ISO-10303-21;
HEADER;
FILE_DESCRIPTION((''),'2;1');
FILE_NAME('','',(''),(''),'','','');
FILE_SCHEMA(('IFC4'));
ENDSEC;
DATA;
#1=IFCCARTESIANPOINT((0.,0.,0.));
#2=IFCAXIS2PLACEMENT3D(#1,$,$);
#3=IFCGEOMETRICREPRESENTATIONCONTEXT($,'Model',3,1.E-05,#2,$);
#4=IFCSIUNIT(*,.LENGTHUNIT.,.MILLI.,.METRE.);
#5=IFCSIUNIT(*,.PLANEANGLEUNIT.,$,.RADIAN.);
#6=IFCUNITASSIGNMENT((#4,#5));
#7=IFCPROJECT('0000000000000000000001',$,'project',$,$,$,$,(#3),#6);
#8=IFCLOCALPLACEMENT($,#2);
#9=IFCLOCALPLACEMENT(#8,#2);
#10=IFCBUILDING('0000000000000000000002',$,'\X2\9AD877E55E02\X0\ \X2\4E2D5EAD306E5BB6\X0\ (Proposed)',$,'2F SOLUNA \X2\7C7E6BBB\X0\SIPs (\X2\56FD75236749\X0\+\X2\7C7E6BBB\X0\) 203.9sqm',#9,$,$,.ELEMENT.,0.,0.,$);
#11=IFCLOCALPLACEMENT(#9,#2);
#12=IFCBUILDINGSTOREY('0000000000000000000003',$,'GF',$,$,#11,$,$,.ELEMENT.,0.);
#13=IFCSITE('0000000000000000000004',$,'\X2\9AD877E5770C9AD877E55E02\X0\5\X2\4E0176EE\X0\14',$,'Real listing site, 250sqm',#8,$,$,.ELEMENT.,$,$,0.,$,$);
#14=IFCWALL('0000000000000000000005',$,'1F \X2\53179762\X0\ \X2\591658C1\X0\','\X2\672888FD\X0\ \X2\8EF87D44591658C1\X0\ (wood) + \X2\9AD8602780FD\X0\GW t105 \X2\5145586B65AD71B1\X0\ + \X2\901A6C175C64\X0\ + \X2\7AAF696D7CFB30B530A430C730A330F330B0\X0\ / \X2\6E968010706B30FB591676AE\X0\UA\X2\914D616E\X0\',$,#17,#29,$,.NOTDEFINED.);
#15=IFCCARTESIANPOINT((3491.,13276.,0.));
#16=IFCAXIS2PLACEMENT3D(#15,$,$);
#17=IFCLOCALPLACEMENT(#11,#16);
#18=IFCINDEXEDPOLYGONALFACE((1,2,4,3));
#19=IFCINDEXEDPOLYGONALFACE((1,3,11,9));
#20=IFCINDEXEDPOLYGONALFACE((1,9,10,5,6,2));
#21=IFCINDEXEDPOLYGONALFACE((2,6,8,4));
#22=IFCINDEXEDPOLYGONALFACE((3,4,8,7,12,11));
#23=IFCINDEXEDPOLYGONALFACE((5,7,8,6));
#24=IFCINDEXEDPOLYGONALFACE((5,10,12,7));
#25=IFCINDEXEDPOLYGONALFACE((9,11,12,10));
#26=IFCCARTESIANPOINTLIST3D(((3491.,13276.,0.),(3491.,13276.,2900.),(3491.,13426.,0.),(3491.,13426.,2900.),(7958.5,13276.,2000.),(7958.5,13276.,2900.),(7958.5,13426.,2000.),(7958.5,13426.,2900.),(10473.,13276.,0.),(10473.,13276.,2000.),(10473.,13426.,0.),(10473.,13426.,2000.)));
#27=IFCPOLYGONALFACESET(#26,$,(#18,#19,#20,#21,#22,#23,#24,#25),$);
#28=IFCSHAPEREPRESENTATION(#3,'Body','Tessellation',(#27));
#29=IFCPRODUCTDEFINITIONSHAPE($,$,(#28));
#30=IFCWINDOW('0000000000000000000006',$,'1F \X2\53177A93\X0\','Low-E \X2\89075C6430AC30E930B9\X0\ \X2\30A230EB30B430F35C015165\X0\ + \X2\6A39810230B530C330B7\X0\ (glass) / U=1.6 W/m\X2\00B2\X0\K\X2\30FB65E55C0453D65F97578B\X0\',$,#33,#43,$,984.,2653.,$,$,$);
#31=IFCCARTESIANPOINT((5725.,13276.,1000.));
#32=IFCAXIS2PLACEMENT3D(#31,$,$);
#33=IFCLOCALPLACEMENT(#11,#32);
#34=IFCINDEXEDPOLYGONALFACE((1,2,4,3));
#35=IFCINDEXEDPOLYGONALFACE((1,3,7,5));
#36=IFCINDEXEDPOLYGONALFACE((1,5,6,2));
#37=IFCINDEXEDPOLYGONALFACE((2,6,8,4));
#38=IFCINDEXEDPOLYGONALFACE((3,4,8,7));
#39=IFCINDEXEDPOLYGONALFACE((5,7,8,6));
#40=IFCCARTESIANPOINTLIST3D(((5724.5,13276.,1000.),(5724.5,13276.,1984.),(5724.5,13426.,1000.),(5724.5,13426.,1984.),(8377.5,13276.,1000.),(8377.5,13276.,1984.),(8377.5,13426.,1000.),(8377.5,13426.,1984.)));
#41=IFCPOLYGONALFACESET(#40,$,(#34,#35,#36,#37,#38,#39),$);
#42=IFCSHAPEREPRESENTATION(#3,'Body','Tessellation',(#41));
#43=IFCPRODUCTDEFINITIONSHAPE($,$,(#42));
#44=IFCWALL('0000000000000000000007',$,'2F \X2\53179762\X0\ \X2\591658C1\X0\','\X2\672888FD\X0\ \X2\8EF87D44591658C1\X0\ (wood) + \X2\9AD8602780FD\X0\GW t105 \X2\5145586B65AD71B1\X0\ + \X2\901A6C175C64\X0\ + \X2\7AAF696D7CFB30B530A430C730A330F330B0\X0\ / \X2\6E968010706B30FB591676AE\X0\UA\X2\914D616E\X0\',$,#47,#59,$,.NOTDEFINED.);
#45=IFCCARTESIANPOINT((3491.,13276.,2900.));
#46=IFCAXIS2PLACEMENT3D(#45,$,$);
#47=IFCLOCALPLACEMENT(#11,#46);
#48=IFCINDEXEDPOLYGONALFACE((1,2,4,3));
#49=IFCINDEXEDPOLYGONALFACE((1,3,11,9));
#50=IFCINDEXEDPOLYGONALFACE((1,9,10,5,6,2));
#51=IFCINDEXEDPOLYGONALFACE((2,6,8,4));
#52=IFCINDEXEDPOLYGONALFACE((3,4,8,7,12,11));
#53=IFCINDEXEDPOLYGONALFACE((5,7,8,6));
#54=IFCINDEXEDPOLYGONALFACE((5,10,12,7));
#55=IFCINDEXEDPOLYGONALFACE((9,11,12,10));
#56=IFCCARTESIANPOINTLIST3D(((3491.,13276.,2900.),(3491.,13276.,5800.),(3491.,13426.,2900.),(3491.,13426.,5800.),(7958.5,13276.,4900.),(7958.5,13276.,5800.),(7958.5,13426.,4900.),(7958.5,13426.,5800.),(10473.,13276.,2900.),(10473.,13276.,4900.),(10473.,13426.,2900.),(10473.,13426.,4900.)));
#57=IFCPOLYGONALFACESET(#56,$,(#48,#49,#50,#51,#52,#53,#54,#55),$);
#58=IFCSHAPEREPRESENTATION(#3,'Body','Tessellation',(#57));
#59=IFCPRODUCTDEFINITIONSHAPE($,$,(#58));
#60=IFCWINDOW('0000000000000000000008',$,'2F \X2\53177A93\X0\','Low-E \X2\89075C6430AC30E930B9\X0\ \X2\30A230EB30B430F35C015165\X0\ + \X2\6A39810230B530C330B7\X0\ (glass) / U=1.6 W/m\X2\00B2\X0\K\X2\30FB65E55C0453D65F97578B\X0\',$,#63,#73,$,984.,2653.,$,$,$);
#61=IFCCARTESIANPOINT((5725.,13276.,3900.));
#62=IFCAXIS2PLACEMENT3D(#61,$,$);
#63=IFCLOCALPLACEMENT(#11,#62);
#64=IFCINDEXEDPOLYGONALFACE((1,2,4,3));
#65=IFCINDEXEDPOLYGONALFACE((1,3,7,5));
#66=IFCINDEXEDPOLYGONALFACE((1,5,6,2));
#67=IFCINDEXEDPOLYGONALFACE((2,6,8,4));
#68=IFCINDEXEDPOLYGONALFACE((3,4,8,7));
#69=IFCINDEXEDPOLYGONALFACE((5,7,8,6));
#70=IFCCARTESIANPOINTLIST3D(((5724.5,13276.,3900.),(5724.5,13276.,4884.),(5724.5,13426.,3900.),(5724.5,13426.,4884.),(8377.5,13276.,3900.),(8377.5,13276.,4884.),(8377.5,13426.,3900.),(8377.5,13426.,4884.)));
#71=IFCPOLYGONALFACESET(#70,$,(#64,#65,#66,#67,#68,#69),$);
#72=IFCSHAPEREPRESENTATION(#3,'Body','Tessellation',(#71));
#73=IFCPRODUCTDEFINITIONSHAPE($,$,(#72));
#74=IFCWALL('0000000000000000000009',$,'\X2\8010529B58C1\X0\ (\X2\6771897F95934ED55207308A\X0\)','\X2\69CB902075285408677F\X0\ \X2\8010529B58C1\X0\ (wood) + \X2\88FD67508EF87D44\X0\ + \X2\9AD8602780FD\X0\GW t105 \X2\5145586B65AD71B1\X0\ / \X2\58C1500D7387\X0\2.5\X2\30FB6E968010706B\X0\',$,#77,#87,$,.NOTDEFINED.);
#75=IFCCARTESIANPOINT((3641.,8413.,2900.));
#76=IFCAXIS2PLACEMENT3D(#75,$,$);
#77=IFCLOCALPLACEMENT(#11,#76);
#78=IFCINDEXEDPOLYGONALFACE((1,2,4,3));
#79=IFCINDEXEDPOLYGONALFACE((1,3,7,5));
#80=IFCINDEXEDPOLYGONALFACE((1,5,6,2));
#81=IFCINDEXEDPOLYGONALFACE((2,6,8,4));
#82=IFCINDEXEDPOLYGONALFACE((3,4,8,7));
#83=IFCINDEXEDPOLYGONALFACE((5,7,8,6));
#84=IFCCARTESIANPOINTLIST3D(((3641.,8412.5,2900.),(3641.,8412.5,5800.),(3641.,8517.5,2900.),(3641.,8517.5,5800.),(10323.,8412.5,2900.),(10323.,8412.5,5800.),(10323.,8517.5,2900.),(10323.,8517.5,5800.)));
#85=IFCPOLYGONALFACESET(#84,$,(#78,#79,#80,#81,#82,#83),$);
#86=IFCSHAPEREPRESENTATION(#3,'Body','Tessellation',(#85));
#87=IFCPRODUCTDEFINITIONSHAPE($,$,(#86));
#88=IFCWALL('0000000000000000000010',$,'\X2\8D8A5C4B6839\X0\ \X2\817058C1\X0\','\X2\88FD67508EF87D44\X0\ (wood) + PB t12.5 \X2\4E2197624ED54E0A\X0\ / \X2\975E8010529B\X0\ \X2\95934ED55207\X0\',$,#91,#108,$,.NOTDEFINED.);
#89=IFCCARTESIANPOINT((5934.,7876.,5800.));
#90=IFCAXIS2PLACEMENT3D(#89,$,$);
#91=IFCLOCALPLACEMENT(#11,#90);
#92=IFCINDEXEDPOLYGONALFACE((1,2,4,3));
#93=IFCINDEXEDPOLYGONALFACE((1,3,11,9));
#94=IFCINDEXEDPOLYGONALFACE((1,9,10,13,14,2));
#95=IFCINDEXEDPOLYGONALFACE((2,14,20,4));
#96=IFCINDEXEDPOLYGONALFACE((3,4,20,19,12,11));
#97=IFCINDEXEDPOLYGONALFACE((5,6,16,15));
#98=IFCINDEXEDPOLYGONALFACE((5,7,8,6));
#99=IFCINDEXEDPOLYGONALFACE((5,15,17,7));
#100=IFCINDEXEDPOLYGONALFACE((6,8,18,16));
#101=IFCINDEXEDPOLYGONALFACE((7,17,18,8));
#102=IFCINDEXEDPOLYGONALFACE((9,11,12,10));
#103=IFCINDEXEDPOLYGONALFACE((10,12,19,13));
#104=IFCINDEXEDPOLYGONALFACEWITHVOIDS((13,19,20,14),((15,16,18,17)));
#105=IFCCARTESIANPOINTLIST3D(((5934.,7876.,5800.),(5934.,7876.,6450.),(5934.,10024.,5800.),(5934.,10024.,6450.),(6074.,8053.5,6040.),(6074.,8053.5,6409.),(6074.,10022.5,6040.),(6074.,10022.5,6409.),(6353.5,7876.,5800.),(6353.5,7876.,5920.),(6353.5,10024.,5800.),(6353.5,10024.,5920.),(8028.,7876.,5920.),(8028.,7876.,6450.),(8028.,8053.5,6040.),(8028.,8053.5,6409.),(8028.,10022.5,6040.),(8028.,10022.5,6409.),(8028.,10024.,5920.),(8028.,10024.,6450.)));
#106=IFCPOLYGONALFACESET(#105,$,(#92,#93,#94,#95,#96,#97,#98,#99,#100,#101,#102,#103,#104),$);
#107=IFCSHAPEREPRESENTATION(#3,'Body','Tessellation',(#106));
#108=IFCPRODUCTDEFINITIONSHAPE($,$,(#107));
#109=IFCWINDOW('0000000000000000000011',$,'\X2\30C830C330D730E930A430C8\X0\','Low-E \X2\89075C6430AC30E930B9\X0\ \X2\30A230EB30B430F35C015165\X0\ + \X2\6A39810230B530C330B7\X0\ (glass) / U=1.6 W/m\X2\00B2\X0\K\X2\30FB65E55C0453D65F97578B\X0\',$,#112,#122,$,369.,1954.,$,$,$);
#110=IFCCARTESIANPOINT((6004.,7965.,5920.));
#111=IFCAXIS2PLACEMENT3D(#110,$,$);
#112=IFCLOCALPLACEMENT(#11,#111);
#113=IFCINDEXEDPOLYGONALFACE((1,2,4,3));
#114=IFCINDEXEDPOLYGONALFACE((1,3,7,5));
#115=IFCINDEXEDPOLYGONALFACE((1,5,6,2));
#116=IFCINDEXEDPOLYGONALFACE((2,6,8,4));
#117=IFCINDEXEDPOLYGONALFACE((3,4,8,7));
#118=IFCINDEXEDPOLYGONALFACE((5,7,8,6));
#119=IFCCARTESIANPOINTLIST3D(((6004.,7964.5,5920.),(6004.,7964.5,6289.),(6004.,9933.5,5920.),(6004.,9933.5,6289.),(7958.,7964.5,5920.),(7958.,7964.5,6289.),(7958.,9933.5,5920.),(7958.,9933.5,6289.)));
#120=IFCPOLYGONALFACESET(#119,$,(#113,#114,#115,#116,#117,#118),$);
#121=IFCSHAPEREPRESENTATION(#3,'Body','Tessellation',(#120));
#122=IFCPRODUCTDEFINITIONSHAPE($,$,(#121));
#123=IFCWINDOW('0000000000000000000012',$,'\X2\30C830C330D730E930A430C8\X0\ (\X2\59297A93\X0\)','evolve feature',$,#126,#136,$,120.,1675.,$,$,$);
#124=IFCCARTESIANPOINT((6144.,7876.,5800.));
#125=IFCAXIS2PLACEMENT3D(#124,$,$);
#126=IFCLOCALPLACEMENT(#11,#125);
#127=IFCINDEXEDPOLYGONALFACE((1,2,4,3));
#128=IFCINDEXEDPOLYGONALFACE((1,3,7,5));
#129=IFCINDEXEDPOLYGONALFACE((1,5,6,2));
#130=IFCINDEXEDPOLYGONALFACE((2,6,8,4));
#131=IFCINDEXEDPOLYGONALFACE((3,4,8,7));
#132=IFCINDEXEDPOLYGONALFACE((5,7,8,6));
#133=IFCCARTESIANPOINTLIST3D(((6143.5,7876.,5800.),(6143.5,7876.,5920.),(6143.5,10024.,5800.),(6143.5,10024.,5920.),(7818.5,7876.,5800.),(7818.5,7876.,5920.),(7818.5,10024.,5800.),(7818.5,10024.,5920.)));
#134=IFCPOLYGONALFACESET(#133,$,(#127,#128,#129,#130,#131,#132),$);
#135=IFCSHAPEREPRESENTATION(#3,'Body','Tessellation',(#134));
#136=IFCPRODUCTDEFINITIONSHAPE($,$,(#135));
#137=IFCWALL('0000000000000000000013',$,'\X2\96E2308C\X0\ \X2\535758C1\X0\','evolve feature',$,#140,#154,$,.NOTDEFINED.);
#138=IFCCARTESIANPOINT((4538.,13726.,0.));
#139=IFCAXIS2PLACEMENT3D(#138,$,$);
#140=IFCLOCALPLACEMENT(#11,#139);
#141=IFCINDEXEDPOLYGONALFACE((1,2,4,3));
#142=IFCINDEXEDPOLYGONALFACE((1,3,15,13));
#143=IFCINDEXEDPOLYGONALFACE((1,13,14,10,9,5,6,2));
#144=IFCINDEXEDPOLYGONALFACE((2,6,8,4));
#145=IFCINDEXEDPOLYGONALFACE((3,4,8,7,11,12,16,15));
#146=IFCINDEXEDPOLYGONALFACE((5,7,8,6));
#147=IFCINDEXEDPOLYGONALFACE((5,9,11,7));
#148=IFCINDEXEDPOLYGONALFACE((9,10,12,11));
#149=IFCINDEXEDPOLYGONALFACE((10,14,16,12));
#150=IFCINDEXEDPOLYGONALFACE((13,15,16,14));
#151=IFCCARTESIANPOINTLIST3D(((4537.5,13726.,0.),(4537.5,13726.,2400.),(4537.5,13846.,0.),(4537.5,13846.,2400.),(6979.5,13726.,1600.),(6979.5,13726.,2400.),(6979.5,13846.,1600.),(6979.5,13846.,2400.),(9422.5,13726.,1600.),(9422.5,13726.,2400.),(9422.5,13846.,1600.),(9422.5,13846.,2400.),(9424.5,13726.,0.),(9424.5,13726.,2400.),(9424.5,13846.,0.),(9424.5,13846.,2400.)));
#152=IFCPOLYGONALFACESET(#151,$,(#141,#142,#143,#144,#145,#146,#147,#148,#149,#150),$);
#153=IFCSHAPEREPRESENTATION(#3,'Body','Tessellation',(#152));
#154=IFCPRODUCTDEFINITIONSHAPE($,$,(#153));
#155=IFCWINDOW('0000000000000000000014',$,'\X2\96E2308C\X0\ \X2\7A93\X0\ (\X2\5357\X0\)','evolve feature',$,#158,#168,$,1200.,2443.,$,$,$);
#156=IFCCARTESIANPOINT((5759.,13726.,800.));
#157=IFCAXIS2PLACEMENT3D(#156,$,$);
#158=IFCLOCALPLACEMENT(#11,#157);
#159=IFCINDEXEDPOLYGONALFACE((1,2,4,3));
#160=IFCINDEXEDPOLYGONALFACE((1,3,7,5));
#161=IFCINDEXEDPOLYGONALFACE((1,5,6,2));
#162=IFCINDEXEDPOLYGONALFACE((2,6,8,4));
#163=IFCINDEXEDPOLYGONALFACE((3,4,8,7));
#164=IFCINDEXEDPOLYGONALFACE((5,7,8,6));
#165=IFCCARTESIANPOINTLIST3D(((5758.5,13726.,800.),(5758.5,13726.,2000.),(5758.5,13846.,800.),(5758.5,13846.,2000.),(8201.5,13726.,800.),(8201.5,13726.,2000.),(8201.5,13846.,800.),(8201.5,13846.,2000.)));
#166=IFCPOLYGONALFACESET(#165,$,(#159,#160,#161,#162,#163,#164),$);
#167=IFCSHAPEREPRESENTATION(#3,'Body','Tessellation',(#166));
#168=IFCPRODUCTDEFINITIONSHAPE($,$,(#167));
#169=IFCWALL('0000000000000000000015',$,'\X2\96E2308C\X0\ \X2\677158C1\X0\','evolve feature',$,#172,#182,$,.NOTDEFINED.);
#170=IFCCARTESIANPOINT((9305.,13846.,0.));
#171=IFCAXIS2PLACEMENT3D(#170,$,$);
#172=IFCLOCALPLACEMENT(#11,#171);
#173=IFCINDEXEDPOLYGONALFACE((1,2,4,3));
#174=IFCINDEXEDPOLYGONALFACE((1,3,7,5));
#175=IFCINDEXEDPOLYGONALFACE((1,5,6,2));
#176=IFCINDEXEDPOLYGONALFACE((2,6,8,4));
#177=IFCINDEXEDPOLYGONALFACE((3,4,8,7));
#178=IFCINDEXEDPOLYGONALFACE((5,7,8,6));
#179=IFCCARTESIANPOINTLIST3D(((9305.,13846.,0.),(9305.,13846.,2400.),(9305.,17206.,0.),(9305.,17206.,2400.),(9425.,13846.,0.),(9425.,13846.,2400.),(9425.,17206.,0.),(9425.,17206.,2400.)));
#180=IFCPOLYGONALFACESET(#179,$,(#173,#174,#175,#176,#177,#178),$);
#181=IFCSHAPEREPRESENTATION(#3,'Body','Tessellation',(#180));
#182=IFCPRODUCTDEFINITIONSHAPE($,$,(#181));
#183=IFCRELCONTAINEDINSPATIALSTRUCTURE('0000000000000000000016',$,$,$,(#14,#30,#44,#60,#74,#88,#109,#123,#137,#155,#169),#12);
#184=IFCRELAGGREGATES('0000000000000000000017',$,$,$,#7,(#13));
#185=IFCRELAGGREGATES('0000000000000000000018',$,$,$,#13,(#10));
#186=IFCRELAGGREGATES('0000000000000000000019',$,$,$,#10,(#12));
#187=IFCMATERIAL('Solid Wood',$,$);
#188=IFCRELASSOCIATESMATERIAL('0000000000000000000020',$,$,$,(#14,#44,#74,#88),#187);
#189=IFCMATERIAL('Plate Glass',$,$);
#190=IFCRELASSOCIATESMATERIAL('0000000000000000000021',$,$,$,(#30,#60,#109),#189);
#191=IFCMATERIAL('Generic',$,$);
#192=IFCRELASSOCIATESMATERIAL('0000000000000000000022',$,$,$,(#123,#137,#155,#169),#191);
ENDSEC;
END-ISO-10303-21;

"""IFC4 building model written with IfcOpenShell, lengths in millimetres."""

from ifc_helpers import new_model, si_unit, frame, frame_2d, origin, place, context, project, spatial, rectangle, extrude, material, element, fill, save


model = new_model("IFC4")

# Units and contexts
model_context = context("Model", 3, precision=1e-05, world=origin())
ifc_project = project(units=[si_unit("LENGTHUNIT", "METRE", prefix="MILLI"), si_unit("PLANEANGLEUNIT", "RADIAN")], contexts=[model_context])

# Site, building, storey
site_placement = place(None, origin())
site = spatial("IfcSite", under=ifc_project, at=site_placement, Name="高知県高知市5丁目14", ObjectType="Real listing site, 250sqm", CompositionType="ELEMENT", RefElevation=0.0)
building_placement = place(site_placement, origin())
building = spatial("IfcBuilding", under=site, at=building_placement, Name="高知市 中庭の家 (Proposed)", ObjectType="2F SOLUNA 籾殻SIPs (国産杉+籾殻) 203.9sqm", CompositionType="ELEMENT", ElevationOfRefHeight=0.0, ElevationOfTerrain=0.0)
storey_placement = place(building_placement, origin())
storey = spatial("IfcBuildingStorey", under=building, at=storey_placement, Name="GF", CompositionType="ELEMENT", Elevation=0.0)

# Shared definitions
ifc_material_1 = material(Name="Generic")

# Wall, opening, window
ifc_material_2 = material(Name="Solid Wood")
wall_1_placement = place(storey_placement, frame((3491.0, 13276.0, 0.0)))
wall_1 = element("IfcWall", 1, at=wall_1_placement, inside=storey, material=ifc_material_2, Name="1F 北面 外壁", Description="木製 軸組外壁 (wood) + 高性能GW t105 充填断熱 + 通気層 + 窯業系サイディング / 準耐火・外皮UA配慮", PredefinedType="NOTDEFINED", context=model_context, shape_type="SweptSolid", body=[
    extrude(rectangle(XDim=6982.0, YDim=150.0, at=frame_2d((3491.0, 75.0))), frame((3491.0, 13276.0, 0.0)), (0.0, 0.0, 1.0), 2900.0),
])
opening_1_placement = place(storey_placement, frame((5725.0, 13276.0, 1000.0)))
opening_1 = element("IfcOpeningElement", 2, at=opening_1_placement, cuts=wall_1, PredefinedType="NOTDEFINED", context=model_context, shape_type="SweptSolid", body=[
    extrude(rectangle(XDim=2653.0, YDim=150.0, at=frame_2d((1326.0, 75.0))), frame((5725.0, 13276.0, 1000.0)), (0.0, 0.0, 1.0), 984.0),
])
ifc_material_3 = material(Name="Plate Glass")
window_1_placement = place(storey_placement, frame((5725.0, 13276.0, 1000.0)))
window_1 = element("IfcWindow", 3, at=window_1_placement, inside=storey, material=ifc_material_3, Name="1F 北窓", Description="Low-E 複層ガラス アルゴン封入 + 樹脂サッシ (glass) / U=1.6 W/m²K・日射取得型", OverallHeight=984.0, OverallWidth=2653.0, context=model_context, shape_type="SweptSolid", body=[
    extrude(rectangle(XDim=2653.0, YDim=150.0, at=frame_2d((1326.0, 75.0))), frame((5725.0, 13276.0, 1000.0)), (0.0, 0.0, 1.0), 984.0),
])
fill(opening_1, window_1)

# Wall, opening, window
wall_2_placement = place(storey_placement, frame((3491.0, 13276.0, 2900.0)))
wall_2 = element("IfcWall", 4, at=wall_2_placement, inside=storey, material=ifc_material_2, Name="2F 北面 外壁", Description="木製 軸組外壁 (wood) + 高性能GW t105 充填断熱 + 通気層 + 窯業系サイディング / 準耐火・外皮UA配慮", PredefinedType="NOTDEFINED", context=model_context, shape_type="SweptSolid", body=[
    extrude(rectangle(XDim=6982.0, YDim=150.0, at=frame_2d((3491.0, 75.0))), frame((3491.0, 13276.0, 2900.0)), (0.0, 0.0, 1.0), 2900.0),
])
opening_2_placement = place(storey_placement, frame((5725.0, 13276.0, 3900.0)))
opening_2 = element("IfcOpeningElement", 5, at=opening_2_placement, cuts=wall_2, PredefinedType="NOTDEFINED", context=model_context, shape_type="SweptSolid", body=[
    extrude(rectangle(XDim=2653.0, YDim=150.0, at=frame_2d((1326.0, 75.0))), frame((5725.0, 13276.0, 3900.0)), (0.0, 0.0, 1.0), 984.0),
])
window_2_placement = place(storey_placement, frame((5725.0, 13276.0, 3900.0)))
window_2 = element("IfcWindow", 6, at=window_2_placement, inside=storey, material=ifc_material_3, Name="2F 北窓", Description="Low-E 複層ガラス アルゴン封入 + 樹脂サッシ (glass) / U=1.6 W/m²K・日射取得型", OverallHeight=984.0, OverallWidth=2653.0, context=model_context, shape_type="SweptSolid", body=[
    extrude(rectangle(XDim=2653.0, YDim=150.0, at=frame_2d((1326.0, 75.0))), frame((5725.0, 13276.0, 3900.0)), (0.0, 0.0, 1.0), 984.0),
])
fill(opening_2, window_2)

# Wall
wall_3_placement = place(storey_placement, frame((3641.0, 8413.0, 2900.0)))
element("IfcWall", 7, at=wall_3_placement, inside=storey, material=ifc_material_2, Name="耐力壁 (東西間仕切り)", Description="構造用合板 耐力壁 (wood) + 製材軸組 + 高性能GW t105 充填断熱 / 壁倍率2.5・準耐火", PredefinedType="NOTDEFINED", context=model_context, shape_type="SweptSolid", body=[
    extrude(rectangle(XDim=6682.0, YDim=105.0, at=frame_2d((3341.0, 52.0))), frame((3641.0, 8413.0, 2900.0)), (0.0, 0.0, 1.0), 2900.0),
])

# Wall, openings, windows
wall_4_placement = place(storey_placement, frame((5934.0, 7876.0, 5800.0)))
wall_4 = element("IfcWall", 8, at=wall_4_placement, inside=storey, material=ifc_material_2, Name="越屋根 腰壁", Description="製材軸組 (wood) + PB t12.5 両面仕上 / 非耐力 間仕切", PredefinedType="NOTDEFINED", context=model_context, shape_type="SweptSolid", body=[
    extrude(rectangle(XDim=2094.0, YDim=2148.0, at=frame_2d((1047.0, 1074.0))), frame((5934.0, 7876.0, 5800.0)), (0.0, 0.0, 1.0), 650.0),
])
opening_3_placement = place(storey_placement, frame((6004.0, 7965.0, 5920.0)))
opening_3 = element("IfcOpeningElement", 9, at=opening_3_placement, cuts=wall_4, PredefinedType="NOTDEFINED", context=model_context, shape_type="SweptSolid", body=[
    extrude(rectangle(XDim=1954.0, YDim=1969.0, at=frame_2d((977.0, 984.0))), frame((6004.0, 7965.0, 5920.0)), (0.0, 0.0, 1.0), 369.0),
])
opening_4_placement = place(storey_placement, frame((6144.0, 7876.0, 5800.0)))
opening_4 = element("IfcOpeningElement", 10, at=opening_4_placement, cuts=wall_4, PredefinedType="NOTDEFINED", context=model_context, shape_type="SweptSolid", body=[
    extrude(rectangle(XDim=1675.0, YDim=2148.0, at=frame_2d((837.0, 1074.0))), frame((6144.0, 7876.0, 5800.0)), (0.0, 0.0, 1.0), 120.0),
])
window_3_placement = place(storey_placement, frame((6004.0, 7965.0, 5920.0)))
window_3 = element("IfcWindow", 11, at=window_3_placement, inside=storey, material=ifc_material_3, Name="トップライト", Description="Low-E 複層ガラス アルゴン封入 + 樹脂サッシ (glass) / U=1.6 W/m²K・日射取得型", OverallHeight=369.0, OverallWidth=1954.0, context=model_context, shape_type="SweptSolid", body=[
    extrude(rectangle(XDim=1954.0, YDim=1969.0, at=frame_2d((977.0, 984.0))), frame((6004.0, 7965.0, 5920.0)), (0.0, 0.0, 1.0), 369.0),
])
fill(opening_3, window_3)
window_4_placement = place(storey_placement, frame((6144.0, 7876.0, 5800.0)))
window_4 = element("IfcWindow", 12, at=window_4_placement, inside=storey, material=ifc_material_1, Name="トップライト (天窓)", Description="evolve feature", OverallHeight=120.0, OverallWidth=1675.0, context=model_context, shape_type="SweptSolid", body=[
    extrude(rectangle(XDim=1675.0, YDim=2148.0, at=frame_2d((837.0, 1074.0))), frame((6144.0, 7876.0, 5800.0)), (0.0, 0.0, 1.0), 120.0),
])
fill(opening_4, window_4)

# Wall, opening, window
wall_5_placement = place(storey_placement, frame((4538.0, 13726.0, 0.0)))
wall_5 = element("IfcWall", 13, at=wall_5_placement, inside=storey, material=ifc_material_1, Name="離れ 南壁", Description="evolve feature", PredefinedType="NOTDEFINED", context=model_context, shape_type="SweptSolid", body=[
    extrude(rectangle(XDim=4887.0, YDim=120.0, at=frame_2d((2443.0, 60.0))), frame((4538.0, 13726.0, 0.0)), (0.0, 0.0, 1.0), 2400.0),
])
opening_5_placement = place(storey_placement, frame((5759.0, 13726.0, 800.0)))
opening_5 = element("IfcOpeningElement", 14, at=opening_5_placement, cuts=wall_5, PredefinedType="NOTDEFINED", context=model_context, shape_type="SweptSolid", body=[
    extrude(rectangle(XDim=2443.0, YDim=120.0, at=frame_2d((1221.0, 60.0))), frame((5759.0, 13726.0, 800.0)), (0.0, 0.0, 1.0), 1200.0),
])
window_5_placement = place(storey_placement, frame((5759.0, 13726.0, 800.0)))
window_5 = element("IfcWindow", 15, at=window_5_placement, inside=storey, material=ifc_material_1, Name="離れ 窓 (南)", Description="evolve feature", OverallHeight=1200.0, OverallWidth=2443.0, context=model_context, shape_type="SweptSolid", body=[
    extrude(rectangle(XDim=2443.0, YDim=120.0, at=frame_2d((1221.0, 60.0))), frame((5759.0, 13726.0, 800.0)), (0.0, 0.0, 1.0), 1200.0),
])
fill(opening_5, window_5)

# Wall
wall_6_placement = place(storey_placement, frame((9305.0, 13846.0, 0.0)))
element("IfcWall", 16, at=wall_6_placement, inside=storey, material=ifc_material_1, Name="離れ 東壁", Description="evolve feature", PredefinedType="NOTDEFINED", context=model_context, shape_type="SweptSolid", body=[
    extrude(rectangle(XDim=120.0, YDim=3360.0, at=frame_2d((60.0, 1680.0))), frame((9305.0, 13846.0, 0.0)), (0.0, 0.0, 1.0), 2400.0),
])

save(model, "model.ifc")
